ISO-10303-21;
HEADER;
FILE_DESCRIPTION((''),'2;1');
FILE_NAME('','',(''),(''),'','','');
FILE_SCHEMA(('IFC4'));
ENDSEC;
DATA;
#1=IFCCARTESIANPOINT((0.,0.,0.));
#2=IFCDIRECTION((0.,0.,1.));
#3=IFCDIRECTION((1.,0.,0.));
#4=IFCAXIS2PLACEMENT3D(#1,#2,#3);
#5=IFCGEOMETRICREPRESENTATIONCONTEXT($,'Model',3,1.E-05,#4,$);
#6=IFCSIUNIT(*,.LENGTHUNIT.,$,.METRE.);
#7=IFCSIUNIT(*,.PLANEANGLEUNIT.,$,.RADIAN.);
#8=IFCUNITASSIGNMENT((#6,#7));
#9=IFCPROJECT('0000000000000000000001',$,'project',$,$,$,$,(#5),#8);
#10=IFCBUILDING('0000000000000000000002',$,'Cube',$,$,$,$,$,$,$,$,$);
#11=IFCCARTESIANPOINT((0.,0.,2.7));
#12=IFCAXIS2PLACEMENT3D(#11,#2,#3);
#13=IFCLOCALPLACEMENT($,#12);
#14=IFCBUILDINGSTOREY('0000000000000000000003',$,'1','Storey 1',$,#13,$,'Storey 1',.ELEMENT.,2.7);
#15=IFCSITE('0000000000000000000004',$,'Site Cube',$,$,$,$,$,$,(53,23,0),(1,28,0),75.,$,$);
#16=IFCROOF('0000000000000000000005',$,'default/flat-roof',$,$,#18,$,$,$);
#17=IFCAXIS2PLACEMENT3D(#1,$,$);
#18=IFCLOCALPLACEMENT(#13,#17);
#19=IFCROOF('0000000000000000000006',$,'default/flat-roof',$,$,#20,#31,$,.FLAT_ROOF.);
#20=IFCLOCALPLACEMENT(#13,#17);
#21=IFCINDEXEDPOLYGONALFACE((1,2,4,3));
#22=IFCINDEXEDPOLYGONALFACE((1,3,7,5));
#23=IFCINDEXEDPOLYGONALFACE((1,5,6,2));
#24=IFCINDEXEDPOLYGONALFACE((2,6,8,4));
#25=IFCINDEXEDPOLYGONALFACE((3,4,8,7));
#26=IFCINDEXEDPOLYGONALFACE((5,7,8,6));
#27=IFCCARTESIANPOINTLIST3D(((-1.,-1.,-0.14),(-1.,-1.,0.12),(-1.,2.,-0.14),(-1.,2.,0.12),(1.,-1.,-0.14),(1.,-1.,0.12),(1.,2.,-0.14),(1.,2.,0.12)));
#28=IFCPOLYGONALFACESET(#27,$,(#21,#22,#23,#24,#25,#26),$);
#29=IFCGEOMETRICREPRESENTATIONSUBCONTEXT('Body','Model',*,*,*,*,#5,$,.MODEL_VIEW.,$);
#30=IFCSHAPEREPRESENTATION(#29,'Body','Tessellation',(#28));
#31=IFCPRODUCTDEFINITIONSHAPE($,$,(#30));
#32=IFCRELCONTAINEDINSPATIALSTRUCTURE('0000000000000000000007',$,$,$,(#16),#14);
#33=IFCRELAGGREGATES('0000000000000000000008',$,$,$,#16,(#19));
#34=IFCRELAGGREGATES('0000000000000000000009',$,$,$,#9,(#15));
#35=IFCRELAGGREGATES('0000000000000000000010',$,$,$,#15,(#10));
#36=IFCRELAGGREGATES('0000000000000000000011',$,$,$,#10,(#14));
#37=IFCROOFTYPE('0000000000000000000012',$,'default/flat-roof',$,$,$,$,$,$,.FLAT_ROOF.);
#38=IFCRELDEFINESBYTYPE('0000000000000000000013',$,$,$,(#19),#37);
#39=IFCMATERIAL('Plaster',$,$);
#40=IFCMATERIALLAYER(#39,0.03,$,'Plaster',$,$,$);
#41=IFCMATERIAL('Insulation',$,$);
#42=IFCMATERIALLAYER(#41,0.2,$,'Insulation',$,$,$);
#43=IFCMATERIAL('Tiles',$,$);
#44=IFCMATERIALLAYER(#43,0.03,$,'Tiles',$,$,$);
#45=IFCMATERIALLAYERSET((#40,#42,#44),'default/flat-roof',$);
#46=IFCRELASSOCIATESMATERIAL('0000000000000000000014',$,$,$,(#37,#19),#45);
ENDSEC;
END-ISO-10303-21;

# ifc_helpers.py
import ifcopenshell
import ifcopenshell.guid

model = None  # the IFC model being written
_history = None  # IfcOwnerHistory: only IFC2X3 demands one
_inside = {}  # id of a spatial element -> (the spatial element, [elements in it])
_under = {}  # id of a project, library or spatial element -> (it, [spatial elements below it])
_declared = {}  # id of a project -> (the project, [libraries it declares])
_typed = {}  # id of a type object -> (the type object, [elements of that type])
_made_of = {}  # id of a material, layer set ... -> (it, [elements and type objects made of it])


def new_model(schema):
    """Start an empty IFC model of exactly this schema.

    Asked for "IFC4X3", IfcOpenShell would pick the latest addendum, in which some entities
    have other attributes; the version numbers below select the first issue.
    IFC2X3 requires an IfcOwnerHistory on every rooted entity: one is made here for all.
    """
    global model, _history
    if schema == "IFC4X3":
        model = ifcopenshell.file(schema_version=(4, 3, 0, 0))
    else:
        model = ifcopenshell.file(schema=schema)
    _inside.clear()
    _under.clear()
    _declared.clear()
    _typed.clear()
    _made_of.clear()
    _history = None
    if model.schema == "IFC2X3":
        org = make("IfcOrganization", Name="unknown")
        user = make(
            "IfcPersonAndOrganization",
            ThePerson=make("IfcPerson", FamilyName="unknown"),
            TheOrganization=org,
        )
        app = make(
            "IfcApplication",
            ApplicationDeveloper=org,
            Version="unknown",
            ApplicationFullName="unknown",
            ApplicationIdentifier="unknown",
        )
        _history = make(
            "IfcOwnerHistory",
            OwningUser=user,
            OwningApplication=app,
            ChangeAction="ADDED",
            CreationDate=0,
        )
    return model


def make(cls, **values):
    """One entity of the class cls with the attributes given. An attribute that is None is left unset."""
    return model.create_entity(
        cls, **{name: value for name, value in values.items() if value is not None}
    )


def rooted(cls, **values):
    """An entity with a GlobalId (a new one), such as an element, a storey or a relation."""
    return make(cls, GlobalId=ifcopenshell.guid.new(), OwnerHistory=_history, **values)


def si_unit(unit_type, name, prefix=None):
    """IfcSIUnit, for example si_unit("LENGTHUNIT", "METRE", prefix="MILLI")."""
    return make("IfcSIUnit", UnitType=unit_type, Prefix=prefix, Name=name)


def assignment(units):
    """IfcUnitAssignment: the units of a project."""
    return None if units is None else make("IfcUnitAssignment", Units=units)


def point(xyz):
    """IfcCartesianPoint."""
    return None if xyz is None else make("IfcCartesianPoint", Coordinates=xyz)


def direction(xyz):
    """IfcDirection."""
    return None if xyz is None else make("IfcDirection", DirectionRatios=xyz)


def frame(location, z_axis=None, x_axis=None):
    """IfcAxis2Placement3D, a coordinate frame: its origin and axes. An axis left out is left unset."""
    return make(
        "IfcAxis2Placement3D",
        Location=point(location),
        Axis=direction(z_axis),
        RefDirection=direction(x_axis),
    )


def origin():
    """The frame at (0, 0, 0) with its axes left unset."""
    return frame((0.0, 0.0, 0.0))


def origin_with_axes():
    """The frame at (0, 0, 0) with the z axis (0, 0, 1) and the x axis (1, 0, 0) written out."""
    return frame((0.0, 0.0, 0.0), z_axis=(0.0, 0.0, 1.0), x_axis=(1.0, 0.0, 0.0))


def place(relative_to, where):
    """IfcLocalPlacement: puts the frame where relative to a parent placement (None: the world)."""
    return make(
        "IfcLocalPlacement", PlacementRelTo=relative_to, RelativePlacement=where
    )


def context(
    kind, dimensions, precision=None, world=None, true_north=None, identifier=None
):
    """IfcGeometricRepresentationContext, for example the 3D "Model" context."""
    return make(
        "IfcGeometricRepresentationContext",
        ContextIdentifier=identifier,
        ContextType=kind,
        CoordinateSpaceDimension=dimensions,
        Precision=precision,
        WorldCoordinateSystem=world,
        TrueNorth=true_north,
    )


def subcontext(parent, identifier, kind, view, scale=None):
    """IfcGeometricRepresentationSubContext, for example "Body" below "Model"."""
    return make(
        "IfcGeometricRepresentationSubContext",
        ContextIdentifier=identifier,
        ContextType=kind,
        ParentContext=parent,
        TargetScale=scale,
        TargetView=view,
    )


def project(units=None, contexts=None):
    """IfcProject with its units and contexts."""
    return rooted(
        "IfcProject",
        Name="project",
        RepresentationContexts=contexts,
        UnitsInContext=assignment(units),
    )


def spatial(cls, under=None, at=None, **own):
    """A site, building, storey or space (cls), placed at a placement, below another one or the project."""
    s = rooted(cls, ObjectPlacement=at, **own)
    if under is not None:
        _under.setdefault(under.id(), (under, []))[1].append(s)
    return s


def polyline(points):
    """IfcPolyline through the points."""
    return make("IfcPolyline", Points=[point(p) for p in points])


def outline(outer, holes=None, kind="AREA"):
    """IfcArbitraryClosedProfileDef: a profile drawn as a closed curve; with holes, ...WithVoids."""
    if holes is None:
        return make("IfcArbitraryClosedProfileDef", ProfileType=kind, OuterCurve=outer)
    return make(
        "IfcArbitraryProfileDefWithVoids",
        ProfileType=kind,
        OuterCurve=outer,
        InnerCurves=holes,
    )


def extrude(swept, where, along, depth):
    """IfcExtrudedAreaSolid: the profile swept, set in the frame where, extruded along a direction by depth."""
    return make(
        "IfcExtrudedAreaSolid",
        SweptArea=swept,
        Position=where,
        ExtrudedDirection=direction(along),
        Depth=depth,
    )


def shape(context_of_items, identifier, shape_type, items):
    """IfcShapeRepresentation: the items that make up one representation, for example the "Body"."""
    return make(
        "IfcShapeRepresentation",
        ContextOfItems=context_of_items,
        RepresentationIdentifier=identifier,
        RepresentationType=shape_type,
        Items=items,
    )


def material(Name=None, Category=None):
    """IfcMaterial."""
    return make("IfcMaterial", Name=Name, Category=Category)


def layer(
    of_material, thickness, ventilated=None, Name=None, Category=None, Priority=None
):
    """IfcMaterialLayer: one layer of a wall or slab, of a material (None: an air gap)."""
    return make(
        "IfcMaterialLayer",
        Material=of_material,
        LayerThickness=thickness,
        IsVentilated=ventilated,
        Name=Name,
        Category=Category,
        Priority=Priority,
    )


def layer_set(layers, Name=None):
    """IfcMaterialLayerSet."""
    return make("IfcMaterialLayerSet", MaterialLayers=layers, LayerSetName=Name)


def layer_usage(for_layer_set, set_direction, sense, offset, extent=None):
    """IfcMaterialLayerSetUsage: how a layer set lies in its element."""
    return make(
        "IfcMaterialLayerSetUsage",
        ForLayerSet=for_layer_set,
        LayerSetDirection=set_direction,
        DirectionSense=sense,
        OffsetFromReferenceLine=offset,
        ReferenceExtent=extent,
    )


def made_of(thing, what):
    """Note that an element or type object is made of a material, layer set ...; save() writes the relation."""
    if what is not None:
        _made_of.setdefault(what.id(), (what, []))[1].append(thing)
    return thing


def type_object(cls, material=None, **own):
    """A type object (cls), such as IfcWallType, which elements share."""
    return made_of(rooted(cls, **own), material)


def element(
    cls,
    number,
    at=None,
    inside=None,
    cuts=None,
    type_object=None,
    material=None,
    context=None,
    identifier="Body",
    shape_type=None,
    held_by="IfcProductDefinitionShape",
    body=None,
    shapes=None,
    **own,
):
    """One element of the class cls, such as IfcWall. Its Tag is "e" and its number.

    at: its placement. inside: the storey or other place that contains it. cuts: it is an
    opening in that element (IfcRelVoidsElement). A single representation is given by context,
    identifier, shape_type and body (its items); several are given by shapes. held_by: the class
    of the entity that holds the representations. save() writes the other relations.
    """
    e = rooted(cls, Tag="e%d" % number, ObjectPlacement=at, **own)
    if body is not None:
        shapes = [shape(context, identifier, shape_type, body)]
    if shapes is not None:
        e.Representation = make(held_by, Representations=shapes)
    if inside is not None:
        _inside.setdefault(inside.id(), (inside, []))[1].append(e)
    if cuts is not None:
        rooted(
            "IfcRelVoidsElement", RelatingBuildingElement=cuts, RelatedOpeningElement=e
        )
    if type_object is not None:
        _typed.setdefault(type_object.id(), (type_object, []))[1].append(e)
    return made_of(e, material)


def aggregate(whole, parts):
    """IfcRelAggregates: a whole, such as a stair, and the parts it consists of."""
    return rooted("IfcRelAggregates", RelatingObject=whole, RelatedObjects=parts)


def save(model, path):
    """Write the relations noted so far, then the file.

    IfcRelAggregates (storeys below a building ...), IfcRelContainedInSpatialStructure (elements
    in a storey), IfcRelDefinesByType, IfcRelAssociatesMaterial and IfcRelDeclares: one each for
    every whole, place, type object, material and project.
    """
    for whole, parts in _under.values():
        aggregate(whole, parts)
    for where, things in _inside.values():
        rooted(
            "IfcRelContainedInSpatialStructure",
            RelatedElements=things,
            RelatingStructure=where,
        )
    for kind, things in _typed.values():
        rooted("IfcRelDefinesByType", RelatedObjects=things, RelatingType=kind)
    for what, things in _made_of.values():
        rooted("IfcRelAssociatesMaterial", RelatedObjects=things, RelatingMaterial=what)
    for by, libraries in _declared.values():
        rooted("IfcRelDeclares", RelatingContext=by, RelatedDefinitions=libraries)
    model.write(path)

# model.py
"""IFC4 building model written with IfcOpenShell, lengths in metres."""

from ifc_helpers import new_model, si_unit, frame, origin, origin_with_axes, place, context, subcontext, project, spatial, polyline, outline, extrude, material, layer, layer_set, layer_usage, type_object, element, aggregate, save


model = new_model("IFC4")

# Units and contexts
model_context = context("Model", 3, precision=1e-05, world=origin_with_axes())
body_context = subcontext(model_context, "Body", "Model", "MODEL_VIEW")
ifc_project = project(units=[si_unit("LENGTHUNIT", "METRE"), si_unit("PLANEANGLEUNIT", "RADIAN")], contexts=[model_context])

# Site, building, storey
site = spatial("IfcSite", under=ifc_project, Name="Site Cube", RefLatitude=(53, 23, 0), RefLongitude=(1, 28, 0), RefElevation=75.0)
building = spatial("IfcBuilding", under=site, Name="Cube")
storey_placement = place(None, frame((0.0, 0.0, 2.7), z_axis=(0.0, 0.0, 1.0), x_axis=(1.0, 0.0, 0.0)))
storey = spatial("IfcBuildingStorey", under=building, at=storey_placement, Name="1", Description="Storey 1", LongName="Storey 1", CompositionType="ELEMENT", Elevation=2.7)

# Roofs
roof_1_placement = place(storey_placement, frame((0.0, 0.0, -2.7), z_axis=(0.0, 0.0, 1.0), x_axis=(1.0, 0.0, 0.0)))
roof_1 = element("IfcRoof", 1, at=roof_1_placement, inside=storey, Name="default/flat-roof")
ifc_material_1 = material(Name="Plaster")
ifc_layer_1 = layer(ifc_material_1, 0.03, Name="Plaster")
ifc_material_2 = material(Name="Insulation")
ifc_layer_2 = layer(ifc_material_2, 0.2, Name="Insulation")
ifc_material_3 = material(Name="Tiles")
ifc_layer_3 = layer(ifc_material_3, 0.03, Name="Tiles")
ifc_layer_set = layer_set([ifc_layer_1, ifc_layer_2, ifc_layer_3], Name="default/flat-roof")
ifc_layer_usage = layer_usage(ifc_layer_set, "AXIS3", "POSITIVE", 0.0)
roof_type = type_object("IfcRoofType", Name="default/flat-roof", PredefinedType="FLAT_ROOF", material=ifc_layer_set)
roof_2_placement = place(roof_1_placement, frame((1.0, 2.0, 2.56), z_axis=(0.0, 0.0, 1.0), x_axis=(0.0, 1.0, 0.0)))
roof_2 = element("IfcRoof", 2, at=roof_2_placement, type_object=roof_type, material=ifc_layer_usage, Name="default/flat-roof", PredefinedType="FLAT_ROOF", context=body_context, shape_type="SweptSolid", body=[
    extrude(outline(polyline([(0.0, 0.0), (0.0, 2.0), (-3.0, 2.0), (-3.0, 0.0), (0.0, 0.0)])), origin(), (0.0, 0.0, 1.0), 0.26),
])
aggregate(roof_1, [roof_2])

save(model, "model.ifc")
